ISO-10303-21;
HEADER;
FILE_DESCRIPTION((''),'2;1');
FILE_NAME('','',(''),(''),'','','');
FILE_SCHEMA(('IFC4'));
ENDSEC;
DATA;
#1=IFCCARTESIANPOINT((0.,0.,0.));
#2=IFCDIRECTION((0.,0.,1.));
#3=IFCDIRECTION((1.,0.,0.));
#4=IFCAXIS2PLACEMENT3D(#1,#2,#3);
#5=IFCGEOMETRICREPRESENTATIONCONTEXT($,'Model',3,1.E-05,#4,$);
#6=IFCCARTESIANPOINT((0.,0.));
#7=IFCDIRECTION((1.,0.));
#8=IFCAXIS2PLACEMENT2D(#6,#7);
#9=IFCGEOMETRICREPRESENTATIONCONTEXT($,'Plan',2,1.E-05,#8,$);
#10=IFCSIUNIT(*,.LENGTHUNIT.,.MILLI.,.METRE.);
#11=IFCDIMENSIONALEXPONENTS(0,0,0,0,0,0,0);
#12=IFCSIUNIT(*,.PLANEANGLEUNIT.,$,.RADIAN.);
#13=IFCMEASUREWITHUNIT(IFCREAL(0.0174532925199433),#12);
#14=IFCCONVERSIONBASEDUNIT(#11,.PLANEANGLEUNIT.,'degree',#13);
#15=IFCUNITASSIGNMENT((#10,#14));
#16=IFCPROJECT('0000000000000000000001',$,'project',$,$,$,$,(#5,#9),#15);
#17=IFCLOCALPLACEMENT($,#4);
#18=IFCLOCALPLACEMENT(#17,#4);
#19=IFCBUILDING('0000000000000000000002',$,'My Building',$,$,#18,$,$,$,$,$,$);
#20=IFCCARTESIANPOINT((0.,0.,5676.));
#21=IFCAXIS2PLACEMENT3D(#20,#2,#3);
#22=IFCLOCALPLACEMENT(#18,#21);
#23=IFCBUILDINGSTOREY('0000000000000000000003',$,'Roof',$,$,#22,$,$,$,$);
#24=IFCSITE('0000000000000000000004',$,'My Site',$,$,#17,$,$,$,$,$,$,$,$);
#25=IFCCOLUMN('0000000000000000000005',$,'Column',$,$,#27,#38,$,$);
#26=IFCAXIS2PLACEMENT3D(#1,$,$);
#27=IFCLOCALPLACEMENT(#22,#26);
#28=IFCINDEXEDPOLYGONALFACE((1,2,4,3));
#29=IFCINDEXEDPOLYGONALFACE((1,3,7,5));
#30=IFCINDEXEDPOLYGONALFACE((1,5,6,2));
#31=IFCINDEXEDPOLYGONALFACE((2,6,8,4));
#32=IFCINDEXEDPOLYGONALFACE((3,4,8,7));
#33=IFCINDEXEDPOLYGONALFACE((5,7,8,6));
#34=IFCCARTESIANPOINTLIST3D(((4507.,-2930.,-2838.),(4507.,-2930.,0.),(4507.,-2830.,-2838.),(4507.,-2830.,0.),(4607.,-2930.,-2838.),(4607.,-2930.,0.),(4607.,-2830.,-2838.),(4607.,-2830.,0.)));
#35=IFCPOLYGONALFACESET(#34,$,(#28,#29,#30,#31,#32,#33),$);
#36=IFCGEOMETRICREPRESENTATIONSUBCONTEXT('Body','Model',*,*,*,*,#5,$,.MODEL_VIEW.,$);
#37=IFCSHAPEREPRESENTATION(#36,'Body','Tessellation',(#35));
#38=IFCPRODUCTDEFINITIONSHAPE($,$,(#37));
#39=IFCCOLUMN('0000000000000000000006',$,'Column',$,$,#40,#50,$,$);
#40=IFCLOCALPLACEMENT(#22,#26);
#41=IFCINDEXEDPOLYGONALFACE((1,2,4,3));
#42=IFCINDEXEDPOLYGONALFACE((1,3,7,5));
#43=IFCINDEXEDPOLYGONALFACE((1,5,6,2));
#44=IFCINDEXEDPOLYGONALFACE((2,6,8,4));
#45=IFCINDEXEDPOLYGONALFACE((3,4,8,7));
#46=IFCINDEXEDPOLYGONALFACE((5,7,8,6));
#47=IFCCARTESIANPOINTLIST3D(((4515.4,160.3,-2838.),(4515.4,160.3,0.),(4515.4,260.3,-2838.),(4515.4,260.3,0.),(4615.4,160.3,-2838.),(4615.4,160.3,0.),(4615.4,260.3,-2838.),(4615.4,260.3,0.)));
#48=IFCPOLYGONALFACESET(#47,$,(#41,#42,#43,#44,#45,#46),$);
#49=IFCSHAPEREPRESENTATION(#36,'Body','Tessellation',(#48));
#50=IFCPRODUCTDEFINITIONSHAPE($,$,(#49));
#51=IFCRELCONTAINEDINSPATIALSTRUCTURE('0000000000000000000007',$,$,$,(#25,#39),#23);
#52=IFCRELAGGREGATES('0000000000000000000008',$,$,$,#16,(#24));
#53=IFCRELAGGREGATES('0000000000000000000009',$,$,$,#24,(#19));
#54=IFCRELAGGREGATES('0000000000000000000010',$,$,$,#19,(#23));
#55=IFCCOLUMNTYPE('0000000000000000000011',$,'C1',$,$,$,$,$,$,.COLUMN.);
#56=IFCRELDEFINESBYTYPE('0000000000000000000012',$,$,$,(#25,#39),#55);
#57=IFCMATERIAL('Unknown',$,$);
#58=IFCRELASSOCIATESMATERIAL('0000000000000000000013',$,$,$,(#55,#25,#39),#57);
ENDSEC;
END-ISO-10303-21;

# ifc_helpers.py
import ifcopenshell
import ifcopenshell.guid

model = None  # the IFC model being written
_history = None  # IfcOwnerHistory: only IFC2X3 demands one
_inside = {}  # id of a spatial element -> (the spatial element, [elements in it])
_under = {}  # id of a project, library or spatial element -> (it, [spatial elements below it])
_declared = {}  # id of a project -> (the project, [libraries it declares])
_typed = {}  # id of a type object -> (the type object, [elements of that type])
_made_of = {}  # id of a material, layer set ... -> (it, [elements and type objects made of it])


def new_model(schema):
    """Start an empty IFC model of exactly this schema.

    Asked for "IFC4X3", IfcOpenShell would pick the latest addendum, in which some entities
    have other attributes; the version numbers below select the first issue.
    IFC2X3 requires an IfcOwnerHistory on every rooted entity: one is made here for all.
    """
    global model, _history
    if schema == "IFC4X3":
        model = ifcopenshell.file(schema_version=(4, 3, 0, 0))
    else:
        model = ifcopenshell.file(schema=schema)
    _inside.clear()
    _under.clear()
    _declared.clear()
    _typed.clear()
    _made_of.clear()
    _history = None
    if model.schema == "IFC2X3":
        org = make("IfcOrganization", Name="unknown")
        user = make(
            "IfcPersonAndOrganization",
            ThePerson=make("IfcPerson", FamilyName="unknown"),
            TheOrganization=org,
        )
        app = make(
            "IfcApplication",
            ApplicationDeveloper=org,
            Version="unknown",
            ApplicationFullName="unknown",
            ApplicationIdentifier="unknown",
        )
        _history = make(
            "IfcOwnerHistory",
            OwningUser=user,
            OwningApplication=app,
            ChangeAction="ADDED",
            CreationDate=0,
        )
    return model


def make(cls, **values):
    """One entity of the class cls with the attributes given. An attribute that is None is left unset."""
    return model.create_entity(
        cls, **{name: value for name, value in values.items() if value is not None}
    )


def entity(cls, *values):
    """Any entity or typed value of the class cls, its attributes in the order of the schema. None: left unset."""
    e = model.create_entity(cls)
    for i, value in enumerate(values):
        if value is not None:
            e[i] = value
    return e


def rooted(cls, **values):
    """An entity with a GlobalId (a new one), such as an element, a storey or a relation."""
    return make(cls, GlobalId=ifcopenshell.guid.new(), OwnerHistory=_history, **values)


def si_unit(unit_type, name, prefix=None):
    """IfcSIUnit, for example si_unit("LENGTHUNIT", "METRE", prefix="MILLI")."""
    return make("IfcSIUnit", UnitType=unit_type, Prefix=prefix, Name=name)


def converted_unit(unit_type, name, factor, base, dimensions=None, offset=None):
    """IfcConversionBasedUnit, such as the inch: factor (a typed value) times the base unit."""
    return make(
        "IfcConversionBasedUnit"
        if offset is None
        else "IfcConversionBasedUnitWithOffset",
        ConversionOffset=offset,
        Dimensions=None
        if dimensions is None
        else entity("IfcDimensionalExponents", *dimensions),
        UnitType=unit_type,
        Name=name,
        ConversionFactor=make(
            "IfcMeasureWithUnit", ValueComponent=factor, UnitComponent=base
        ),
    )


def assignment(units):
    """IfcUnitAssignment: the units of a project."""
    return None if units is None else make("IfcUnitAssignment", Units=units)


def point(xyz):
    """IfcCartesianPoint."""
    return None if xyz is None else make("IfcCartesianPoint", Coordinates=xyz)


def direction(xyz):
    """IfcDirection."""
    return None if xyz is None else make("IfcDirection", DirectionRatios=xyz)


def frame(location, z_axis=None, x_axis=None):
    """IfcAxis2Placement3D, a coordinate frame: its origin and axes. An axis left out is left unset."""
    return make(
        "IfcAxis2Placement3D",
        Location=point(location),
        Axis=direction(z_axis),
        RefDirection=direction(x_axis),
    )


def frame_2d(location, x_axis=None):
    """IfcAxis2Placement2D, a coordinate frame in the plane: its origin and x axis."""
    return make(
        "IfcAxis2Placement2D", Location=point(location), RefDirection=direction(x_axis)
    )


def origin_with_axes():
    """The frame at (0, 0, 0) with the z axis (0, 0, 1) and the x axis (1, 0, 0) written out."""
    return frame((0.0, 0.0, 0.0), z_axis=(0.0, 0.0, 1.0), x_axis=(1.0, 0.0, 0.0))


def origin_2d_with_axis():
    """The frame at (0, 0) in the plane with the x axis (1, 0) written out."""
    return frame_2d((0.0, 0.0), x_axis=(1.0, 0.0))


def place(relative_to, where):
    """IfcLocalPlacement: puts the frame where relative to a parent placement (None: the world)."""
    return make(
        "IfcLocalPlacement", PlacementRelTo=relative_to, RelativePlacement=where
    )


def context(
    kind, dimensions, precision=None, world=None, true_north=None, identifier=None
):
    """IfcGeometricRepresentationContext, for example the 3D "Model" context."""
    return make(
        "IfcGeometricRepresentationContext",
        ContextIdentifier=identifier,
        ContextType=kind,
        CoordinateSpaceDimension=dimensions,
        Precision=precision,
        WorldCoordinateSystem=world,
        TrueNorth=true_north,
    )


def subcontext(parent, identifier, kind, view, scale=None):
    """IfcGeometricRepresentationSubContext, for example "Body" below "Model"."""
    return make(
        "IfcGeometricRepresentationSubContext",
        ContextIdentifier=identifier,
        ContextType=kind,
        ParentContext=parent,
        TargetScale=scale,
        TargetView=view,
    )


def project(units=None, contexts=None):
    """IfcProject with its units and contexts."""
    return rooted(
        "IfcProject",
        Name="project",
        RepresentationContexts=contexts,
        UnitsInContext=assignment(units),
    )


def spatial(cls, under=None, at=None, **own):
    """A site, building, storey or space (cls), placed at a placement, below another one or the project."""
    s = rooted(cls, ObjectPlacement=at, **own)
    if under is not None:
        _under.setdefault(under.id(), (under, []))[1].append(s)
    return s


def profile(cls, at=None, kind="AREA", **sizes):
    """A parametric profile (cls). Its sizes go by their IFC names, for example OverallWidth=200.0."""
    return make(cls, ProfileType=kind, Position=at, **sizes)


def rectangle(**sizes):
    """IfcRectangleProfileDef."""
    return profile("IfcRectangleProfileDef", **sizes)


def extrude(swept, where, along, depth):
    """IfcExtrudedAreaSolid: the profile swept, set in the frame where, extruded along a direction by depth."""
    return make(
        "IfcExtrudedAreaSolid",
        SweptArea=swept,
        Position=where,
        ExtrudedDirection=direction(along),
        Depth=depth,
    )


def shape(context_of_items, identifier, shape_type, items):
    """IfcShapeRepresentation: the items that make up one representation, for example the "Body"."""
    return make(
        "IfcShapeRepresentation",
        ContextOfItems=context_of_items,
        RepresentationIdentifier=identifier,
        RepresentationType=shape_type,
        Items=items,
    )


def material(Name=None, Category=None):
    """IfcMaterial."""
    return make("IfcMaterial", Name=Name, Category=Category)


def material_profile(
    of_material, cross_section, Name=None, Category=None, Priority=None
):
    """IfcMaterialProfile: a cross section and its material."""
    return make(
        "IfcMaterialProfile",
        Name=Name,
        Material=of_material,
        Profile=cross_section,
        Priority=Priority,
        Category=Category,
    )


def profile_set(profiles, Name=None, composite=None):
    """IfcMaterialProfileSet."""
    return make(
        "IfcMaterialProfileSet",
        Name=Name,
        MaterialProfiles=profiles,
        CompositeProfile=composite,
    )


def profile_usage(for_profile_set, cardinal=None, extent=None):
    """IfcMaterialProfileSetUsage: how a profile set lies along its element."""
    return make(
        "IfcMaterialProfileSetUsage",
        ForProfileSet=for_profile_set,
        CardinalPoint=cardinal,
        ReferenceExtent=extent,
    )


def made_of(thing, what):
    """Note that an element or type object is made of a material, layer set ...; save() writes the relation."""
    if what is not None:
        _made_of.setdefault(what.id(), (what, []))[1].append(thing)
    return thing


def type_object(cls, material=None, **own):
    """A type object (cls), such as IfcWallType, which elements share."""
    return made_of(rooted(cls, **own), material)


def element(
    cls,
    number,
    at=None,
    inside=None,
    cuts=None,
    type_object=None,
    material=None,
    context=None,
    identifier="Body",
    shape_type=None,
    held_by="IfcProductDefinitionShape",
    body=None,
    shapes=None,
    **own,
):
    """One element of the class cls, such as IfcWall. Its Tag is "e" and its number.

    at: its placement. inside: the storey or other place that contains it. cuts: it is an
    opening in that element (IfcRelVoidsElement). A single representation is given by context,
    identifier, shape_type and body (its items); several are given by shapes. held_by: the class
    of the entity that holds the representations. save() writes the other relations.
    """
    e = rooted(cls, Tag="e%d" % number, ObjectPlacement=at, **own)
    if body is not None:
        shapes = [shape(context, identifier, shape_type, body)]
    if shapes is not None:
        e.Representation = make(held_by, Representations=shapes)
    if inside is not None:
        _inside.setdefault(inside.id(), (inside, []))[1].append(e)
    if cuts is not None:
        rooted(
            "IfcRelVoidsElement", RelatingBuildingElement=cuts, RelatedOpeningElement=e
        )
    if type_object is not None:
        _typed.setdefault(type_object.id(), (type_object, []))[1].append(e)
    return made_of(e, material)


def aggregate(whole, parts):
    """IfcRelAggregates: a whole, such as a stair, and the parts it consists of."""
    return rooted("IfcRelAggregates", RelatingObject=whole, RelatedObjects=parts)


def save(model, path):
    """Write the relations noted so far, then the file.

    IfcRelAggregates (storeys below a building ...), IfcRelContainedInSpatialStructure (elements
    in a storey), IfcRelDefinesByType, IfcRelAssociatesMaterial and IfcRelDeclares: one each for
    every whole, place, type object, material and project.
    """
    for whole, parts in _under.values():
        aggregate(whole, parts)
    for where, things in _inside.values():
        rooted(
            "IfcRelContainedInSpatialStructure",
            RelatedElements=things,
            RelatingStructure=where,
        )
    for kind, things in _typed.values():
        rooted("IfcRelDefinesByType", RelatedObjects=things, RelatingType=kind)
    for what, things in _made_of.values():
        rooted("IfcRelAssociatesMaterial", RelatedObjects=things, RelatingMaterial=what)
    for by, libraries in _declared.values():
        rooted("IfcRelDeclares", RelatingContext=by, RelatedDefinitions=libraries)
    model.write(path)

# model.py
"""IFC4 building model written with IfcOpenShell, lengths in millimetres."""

from ifc_helpers import new_model, entity, si_unit, converted_unit, frame, origin_with_axes, origin_2d_with_axis, place, context, subcontext, project, spatial, rectangle, extrude, material, material_profile, profile_set, profile_usage, type_object, element, save


model = new_model("IFC4")

# Units and contexts
model_context = context("Model", 3, precision=1e-05, world=origin_with_axes())
plan_context = context("Plan", 2, precision=1e-05, world=origin_2d_with_axis())
body_context = subcontext(model_context, "Body", "Model", "MODEL_VIEW")
ifc_project = project(units=[si_unit("LENGTHUNIT", "METRE", prefix="MILLI"), converted_unit("PLANEANGLEUNIT", "degree", entity("IfcReal", 0.0174532925199433), si_unit("PLANEANGLEUNIT", "RADIAN"), dimensions=[0, 0, 0, 0, 0, 0, 0])], contexts=[model_context, plan_context])

# Site, building, storey
site_placement = place(None, origin_with_axes())
site = spatial("IfcSite", under=ifc_project, at=site_placement, Name="My Site")
building_placement = place(site_placement, origin_with_axes())
building = spatial("IfcBuilding", under=site, at=building_placement, Name="My Building")
storey_placement = place(building_placement, frame((0.0, 0.0, 5676.0), z_axis=(0.0, 0.0, 1.0), x_axis=(1.0, 0.0, 0.0)))
storey = spatial("IfcBuildingStorey", under=building, at=storey_placement, Name="Roof")

# Columns
ifc_material = material(Name="Unknown")
ifc_material_profile_1 = material_profile(ifc_material, rectangle(XDim=100.0, YDim=100.0))
ifc_profile_set_1 = profile_set([ifc_material_profile_1])
ifc_profile_usage_1 = profile_usage(ifc_profile_set_1, cardinal=5)
column_type = type_object("IfcColumnType", Name="C1", PredefinedType="COLUMN", material=ifc_profile_set_1)
column_1_placement = place(storey_placement, frame((4557.0, -2880.0, -2838.0), z_axis=(0.0, 0.0, 1.0), x_axis=(1.0, 0.0, 0.0)))
element("IfcColumn", 1, at=column_1_placement, inside=storey, type_object=column_type, material=ifc_profile_usage_1, Name="Column", context=body_context, shape_type="SweptSolid", body=[
    extrude(rectangle(XDim=100.0, YDim=100.0), origin_with_axes(), (0.0, 0.0, 1.0), 2838.0),
])
ifc_profile_usage_2 = profile_usage(ifc_profile_set_1, cardinal=5)
column_2_placement = place(storey_placement, frame((4565.4, 210.3, -2838.0), z_axis=(0.0, 0.0, 1.0), x_axis=(1.0, 0.0, 0.0)))
element("IfcColumn", 2, at=column_2_placement, inside=storey, type_object=column_type, material=ifc_profile_usage_2, Name="Column", context=body_context, shape_type="SweptSolid", body=[
    extrude(rectangle(XDim=100.0, YDim=100.0), origin_with_axes(), (0.0, 0.0, 1.0), 2838.0),
])

save(model, "model.ifc")
